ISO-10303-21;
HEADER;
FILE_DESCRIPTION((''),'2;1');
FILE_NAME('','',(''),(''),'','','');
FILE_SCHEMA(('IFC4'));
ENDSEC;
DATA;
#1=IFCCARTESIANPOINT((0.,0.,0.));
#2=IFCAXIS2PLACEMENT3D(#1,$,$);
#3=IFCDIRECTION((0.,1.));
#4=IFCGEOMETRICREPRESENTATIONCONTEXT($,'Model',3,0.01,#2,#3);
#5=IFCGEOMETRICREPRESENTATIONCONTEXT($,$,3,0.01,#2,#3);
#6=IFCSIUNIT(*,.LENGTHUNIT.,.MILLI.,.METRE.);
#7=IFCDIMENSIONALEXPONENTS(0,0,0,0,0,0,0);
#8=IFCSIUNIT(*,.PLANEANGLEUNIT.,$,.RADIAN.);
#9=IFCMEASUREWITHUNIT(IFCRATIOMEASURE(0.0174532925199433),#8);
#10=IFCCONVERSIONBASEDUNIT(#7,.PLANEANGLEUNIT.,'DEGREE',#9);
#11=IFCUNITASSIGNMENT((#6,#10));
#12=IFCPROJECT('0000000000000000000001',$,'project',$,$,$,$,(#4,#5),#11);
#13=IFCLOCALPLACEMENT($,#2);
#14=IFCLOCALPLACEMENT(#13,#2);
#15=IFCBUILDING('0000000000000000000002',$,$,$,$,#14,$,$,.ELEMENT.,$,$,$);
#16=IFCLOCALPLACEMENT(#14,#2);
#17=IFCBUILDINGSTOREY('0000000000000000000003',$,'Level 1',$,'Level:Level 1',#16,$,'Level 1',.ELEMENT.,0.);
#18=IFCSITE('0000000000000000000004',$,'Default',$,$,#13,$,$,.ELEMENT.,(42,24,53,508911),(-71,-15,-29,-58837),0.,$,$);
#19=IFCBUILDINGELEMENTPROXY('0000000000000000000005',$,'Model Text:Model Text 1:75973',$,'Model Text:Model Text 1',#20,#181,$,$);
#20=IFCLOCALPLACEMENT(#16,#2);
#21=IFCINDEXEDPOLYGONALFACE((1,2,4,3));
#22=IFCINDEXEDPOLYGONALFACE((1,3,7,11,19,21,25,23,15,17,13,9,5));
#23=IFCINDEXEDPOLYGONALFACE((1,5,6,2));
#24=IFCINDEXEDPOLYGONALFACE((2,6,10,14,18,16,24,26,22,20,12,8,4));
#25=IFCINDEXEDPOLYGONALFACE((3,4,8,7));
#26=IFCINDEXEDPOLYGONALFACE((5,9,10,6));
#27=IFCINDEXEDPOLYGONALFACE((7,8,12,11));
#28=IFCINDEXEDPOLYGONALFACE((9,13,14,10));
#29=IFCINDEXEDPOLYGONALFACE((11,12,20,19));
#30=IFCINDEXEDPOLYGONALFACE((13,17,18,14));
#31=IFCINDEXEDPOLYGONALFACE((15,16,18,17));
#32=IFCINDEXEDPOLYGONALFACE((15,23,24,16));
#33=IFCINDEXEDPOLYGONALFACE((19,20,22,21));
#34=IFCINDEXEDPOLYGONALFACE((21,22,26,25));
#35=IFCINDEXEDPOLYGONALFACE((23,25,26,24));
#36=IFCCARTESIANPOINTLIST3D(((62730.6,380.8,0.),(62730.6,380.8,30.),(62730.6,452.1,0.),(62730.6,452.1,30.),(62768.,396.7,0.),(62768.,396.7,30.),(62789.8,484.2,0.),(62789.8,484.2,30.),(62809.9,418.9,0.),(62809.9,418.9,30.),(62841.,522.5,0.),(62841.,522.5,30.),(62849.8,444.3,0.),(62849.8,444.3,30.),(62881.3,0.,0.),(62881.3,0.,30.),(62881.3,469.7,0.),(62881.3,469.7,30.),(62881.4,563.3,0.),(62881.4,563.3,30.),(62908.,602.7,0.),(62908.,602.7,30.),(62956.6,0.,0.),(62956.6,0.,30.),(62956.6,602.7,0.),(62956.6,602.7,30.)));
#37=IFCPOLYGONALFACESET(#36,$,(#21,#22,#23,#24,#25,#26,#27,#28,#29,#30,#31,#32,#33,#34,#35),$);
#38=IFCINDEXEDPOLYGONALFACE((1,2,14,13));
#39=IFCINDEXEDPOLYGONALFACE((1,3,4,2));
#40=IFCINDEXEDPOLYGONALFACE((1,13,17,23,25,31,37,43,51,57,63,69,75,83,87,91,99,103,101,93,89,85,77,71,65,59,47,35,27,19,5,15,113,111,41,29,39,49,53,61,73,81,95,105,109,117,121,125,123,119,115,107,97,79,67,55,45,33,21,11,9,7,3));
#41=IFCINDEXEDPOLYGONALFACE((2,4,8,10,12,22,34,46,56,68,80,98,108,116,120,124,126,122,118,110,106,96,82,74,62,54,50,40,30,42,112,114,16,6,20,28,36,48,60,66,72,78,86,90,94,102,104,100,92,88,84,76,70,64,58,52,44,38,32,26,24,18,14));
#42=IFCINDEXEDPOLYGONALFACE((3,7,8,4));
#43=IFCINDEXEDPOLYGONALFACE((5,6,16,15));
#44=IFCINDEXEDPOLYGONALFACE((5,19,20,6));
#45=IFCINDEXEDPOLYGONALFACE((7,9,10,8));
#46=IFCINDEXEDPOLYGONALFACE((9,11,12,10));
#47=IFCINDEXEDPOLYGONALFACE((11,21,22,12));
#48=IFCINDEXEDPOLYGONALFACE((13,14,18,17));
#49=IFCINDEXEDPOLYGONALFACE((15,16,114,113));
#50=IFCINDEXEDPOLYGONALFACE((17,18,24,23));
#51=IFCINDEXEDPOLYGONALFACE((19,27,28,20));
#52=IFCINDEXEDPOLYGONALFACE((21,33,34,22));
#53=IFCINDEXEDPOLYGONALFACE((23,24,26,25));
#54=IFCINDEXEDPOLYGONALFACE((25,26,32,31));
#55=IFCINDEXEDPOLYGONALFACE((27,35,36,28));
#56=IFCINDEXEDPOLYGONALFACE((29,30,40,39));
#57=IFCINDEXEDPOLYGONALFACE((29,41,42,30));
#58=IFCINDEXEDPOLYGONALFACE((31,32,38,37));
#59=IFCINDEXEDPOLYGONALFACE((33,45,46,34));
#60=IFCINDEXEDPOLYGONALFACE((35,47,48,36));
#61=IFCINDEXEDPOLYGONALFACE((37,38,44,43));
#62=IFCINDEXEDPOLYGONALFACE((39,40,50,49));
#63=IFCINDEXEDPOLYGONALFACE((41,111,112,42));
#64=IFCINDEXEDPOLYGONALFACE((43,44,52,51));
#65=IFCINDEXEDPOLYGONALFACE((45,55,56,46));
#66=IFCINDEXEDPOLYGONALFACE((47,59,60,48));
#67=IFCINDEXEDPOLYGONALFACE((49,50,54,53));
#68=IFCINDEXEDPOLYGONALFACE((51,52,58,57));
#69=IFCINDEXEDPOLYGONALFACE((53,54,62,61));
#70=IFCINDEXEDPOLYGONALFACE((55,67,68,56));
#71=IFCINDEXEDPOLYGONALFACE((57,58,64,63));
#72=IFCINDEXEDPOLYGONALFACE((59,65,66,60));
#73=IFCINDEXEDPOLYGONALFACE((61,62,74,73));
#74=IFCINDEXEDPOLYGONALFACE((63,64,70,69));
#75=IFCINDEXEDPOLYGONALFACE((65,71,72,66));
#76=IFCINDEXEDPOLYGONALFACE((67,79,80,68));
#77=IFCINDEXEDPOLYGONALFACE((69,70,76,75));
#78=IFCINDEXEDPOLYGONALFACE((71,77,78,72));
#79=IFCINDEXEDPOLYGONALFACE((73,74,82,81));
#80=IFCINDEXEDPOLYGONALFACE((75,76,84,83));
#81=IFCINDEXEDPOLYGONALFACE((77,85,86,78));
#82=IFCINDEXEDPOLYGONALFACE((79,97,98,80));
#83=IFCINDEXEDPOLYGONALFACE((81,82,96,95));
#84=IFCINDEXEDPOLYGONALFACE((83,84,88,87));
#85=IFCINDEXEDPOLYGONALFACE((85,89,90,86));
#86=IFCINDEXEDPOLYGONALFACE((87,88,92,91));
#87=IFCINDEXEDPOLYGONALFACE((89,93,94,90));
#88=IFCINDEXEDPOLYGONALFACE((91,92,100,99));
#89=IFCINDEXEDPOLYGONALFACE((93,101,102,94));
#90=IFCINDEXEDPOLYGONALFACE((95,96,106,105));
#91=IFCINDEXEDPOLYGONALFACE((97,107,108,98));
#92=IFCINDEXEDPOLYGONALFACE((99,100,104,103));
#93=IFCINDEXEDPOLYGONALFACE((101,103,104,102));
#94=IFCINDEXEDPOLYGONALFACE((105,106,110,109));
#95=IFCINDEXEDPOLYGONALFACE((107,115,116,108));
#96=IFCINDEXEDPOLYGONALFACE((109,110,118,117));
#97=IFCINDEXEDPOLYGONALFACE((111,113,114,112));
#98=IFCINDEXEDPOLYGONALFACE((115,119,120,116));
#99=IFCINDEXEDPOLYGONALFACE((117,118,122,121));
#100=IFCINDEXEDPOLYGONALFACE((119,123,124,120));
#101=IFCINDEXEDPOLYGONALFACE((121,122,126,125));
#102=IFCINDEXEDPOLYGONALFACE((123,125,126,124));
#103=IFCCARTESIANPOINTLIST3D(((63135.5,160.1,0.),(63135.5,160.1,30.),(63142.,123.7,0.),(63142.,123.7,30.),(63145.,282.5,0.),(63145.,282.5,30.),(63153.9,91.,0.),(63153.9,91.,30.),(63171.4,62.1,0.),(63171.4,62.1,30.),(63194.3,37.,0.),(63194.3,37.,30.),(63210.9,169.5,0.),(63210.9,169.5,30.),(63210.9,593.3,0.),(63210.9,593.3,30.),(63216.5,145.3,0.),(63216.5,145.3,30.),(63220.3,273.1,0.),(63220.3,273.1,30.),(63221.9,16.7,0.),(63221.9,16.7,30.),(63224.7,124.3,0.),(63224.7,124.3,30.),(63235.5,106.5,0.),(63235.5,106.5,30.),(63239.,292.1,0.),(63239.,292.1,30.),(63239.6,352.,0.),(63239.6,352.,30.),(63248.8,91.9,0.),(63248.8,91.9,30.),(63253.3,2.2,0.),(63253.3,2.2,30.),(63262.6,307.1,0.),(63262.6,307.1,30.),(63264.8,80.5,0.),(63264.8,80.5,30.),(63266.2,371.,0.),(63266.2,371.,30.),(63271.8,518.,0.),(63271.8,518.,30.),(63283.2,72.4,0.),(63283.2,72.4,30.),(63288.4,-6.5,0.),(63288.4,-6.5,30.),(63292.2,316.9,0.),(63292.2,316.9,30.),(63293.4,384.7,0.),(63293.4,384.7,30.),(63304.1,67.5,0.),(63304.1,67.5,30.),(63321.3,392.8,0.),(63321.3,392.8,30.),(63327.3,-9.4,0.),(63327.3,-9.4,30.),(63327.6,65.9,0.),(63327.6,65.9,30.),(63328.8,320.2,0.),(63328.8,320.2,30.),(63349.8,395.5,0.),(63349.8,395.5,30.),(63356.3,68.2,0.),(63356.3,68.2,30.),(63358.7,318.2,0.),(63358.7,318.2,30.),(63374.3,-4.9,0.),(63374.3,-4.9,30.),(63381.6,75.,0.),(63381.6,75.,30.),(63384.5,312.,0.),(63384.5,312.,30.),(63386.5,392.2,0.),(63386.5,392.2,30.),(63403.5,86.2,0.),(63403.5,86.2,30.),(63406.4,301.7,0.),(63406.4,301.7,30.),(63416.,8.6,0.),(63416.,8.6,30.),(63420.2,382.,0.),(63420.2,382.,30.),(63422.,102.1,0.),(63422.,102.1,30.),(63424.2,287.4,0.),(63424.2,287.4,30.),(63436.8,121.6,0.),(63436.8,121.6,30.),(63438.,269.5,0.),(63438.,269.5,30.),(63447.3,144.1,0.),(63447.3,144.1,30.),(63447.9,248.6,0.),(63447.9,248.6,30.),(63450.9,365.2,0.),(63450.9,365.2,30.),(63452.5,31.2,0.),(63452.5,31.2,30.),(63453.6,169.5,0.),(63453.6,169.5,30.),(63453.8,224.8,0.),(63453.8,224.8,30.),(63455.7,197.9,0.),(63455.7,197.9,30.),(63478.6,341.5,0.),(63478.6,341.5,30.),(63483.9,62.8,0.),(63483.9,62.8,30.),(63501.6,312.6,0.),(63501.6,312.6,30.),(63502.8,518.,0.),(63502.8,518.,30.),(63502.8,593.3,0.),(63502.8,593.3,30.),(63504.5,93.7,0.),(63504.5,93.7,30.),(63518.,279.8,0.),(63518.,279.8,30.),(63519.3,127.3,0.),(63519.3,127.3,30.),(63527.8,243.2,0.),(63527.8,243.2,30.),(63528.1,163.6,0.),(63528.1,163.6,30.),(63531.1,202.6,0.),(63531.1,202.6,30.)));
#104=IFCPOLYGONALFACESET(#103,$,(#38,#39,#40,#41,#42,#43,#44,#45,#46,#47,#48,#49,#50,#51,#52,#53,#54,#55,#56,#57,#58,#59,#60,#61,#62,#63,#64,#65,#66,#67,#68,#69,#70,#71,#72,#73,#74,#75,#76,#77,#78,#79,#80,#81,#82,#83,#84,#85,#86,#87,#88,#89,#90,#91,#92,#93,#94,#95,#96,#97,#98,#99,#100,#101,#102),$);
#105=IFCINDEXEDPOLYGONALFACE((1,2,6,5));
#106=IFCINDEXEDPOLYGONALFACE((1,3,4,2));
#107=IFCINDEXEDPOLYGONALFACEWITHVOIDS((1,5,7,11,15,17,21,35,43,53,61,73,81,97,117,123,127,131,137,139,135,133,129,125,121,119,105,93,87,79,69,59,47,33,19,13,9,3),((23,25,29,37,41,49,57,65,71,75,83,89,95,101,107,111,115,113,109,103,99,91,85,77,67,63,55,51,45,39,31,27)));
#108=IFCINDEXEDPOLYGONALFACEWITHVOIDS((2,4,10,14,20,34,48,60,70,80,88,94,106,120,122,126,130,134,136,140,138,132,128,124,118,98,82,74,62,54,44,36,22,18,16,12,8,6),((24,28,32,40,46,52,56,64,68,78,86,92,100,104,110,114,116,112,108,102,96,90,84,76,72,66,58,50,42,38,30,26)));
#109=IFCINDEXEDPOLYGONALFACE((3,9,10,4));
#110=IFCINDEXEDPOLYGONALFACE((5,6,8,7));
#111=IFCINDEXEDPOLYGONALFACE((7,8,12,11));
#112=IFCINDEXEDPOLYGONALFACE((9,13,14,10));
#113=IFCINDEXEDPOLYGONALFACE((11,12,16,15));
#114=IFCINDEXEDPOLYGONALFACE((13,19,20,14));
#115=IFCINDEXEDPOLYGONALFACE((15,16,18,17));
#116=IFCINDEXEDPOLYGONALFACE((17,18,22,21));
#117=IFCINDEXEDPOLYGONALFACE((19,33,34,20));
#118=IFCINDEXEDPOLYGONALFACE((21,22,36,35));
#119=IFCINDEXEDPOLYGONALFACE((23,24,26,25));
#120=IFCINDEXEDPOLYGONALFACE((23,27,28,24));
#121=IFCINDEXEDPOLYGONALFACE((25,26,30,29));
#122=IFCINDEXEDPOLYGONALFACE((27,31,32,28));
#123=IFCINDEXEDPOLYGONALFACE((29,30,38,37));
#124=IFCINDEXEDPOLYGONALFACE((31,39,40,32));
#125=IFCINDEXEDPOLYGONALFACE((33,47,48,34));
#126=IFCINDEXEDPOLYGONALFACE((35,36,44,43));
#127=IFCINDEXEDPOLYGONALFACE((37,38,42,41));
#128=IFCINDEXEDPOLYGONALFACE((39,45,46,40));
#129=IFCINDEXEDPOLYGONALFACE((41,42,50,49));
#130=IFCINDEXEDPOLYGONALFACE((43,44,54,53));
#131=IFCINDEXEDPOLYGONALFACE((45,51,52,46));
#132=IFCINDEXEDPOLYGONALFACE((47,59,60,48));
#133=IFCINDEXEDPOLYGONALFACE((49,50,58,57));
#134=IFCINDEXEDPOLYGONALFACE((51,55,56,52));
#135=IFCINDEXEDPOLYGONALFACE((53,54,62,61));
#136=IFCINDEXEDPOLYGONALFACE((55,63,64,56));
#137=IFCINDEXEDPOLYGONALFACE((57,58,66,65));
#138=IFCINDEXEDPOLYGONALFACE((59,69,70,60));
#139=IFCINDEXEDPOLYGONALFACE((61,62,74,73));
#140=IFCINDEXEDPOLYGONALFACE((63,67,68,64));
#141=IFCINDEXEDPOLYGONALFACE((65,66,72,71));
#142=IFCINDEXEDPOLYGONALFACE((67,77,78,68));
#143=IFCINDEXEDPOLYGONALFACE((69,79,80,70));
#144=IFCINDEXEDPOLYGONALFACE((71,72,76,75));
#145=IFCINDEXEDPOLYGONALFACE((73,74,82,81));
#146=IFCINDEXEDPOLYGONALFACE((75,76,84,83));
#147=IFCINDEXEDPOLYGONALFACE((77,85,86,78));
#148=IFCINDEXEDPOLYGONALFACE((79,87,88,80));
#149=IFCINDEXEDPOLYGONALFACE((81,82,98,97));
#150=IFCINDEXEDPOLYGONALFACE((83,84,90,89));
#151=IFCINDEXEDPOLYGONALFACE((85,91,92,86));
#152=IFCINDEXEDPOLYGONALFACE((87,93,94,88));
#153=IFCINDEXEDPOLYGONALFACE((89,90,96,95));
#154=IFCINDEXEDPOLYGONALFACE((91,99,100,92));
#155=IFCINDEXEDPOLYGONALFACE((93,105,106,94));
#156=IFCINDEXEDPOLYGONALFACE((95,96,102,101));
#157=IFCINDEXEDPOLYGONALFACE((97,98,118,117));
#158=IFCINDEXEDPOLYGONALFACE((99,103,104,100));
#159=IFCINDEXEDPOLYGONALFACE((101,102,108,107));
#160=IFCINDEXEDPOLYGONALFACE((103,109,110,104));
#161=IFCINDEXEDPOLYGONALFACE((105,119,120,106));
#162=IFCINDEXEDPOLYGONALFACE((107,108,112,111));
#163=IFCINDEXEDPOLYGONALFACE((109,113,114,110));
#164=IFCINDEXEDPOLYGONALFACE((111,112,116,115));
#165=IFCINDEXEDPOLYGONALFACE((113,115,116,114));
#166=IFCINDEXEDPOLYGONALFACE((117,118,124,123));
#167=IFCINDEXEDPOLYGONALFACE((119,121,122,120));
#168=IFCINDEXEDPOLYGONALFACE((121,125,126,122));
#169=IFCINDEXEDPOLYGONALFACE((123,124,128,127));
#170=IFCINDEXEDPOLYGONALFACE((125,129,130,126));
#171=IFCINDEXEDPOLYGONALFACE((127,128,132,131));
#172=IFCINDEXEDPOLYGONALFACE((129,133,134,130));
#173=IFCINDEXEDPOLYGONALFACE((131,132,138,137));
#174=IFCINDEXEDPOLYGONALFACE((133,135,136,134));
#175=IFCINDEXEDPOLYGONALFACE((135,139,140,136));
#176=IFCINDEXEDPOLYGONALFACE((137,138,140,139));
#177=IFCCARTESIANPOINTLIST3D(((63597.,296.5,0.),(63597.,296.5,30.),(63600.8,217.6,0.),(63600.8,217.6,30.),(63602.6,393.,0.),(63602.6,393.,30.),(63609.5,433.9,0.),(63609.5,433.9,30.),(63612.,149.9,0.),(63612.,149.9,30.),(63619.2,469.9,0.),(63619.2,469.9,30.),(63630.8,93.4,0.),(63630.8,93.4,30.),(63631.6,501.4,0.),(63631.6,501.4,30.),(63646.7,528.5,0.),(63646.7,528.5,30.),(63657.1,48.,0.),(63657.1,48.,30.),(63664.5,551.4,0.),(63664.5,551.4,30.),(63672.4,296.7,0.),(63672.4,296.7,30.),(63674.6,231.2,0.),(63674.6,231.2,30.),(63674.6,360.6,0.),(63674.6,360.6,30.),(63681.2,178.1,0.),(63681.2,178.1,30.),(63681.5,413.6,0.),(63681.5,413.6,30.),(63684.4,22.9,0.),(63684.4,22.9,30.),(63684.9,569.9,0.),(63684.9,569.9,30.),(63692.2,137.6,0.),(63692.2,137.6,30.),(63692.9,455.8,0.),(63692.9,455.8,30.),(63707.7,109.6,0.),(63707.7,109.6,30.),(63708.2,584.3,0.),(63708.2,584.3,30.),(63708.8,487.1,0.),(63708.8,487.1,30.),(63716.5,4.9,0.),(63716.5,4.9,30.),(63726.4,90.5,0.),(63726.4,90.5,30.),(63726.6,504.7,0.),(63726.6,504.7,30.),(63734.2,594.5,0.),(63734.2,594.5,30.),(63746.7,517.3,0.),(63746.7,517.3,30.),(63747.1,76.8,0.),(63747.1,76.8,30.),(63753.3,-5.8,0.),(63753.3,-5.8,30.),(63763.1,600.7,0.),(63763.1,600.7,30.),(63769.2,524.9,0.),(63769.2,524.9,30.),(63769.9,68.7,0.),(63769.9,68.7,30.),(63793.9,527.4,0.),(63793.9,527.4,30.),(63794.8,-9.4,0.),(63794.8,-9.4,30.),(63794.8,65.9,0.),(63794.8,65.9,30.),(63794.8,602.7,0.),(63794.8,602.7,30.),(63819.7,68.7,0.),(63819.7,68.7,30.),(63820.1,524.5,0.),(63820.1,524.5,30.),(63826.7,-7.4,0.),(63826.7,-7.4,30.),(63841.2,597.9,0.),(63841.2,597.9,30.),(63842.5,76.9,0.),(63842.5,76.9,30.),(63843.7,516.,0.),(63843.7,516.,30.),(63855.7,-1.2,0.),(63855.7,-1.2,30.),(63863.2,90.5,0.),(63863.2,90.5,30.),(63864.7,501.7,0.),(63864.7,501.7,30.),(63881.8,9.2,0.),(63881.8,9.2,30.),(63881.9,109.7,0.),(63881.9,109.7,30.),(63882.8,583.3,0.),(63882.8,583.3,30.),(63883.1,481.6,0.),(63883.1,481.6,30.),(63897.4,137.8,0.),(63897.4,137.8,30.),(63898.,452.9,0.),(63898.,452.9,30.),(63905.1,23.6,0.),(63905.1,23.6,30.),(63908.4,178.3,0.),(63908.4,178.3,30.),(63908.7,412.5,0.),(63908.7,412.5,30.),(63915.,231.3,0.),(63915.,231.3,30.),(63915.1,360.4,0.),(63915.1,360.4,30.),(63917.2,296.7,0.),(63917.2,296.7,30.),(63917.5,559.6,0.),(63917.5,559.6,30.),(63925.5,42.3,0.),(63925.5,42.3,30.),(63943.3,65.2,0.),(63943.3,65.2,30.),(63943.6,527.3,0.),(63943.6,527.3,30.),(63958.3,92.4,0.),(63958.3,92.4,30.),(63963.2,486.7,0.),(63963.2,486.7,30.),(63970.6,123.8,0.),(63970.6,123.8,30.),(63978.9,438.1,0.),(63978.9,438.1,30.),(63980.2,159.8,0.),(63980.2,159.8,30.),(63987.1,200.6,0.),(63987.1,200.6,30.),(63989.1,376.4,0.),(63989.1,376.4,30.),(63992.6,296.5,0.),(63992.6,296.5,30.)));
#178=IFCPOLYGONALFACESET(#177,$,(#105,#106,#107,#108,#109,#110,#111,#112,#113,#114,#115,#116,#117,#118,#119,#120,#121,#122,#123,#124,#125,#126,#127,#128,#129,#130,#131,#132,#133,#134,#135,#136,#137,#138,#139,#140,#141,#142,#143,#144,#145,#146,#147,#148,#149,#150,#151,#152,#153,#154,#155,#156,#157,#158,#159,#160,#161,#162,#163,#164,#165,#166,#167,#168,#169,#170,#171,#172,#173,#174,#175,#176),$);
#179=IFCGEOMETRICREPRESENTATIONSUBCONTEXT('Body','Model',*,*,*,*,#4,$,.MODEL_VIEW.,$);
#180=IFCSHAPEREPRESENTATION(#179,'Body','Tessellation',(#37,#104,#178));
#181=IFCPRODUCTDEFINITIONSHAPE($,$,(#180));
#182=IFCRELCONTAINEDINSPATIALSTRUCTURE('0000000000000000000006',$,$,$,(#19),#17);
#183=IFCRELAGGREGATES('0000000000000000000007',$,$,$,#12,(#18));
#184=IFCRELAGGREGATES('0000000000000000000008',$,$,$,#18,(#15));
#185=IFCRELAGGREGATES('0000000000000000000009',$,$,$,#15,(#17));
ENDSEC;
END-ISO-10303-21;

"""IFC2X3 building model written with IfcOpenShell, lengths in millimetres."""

from ifc_helpers import new_model, entity, si_unit, converted_unit, direction, frame, origin, place, context, subcontext, project, spatial, polyline, outline, extrude, element, save


model = new_model("IFC2X3")

# Units and contexts
model_context = context("Model", 3, precision=0.01, world=origin(), true_north=direction((0.0, 1.0)))
context_of_model = context(None, 3, precision=0.01, world=origin(), true_north=direction((0.0, 1.0)))
body_context = subcontext(model_context, "Body", "Model", "MODEL_VIEW")
ifc_project = project(units=[si_unit("LENGTHUNIT", "METRE", prefix="MILLI"), converted_unit("PLANEANGLEUNIT", "DEGREE", entity("IfcRatioMeasure", 0.0174532925199433), si_unit("PLANEANGLEUNIT", "RADIAN"), dimensions=[0, 0, 0, 0, 0, 0, 0])], contexts=[model_context, context_of_model])

# Site, building, storey
site_placement = place(None, origin())
site = spatial("IfcSite", under=ifc_project, at=site_placement, Name="Default", CompositionType="ELEMENT", RefLatitude=(42, 24, 53, 508911), RefLongitude=(-71, -15, -29, -58837), RefElevation=0.0)
building_placement = place(site_placement, origin())
building = spatial("IfcBuilding", under=site, at=building_placement, CompositionType="ELEMENT")
storey_placement = place(building_placement, origin())
storey = spatial("IfcBuildingStorey", under=building, at=storey_placement, Name="Level 1", ObjectType="Level:Level 1", LongName="Level 1", CompositionType="ELEMENT", Elevation=0.0)

# Building element proxy
proxy_1_placement = place(storey_placement, origin())
element("IfcBuildingElementProxy", 1, at=proxy_1_placement, inside=storey, Name="Model Text:Model Text 1:75973", ObjectType="Model Text:Model Text 1", context=body_context, shape_type="SweptSolid", body=[
    extrude(outline(polyline([(-410.6, -111.6), (192.1, -111.6), (192.1, -63.1), (152.7, -36.4), (111.9, 4.0), (73.6, 55.2), (41.4, 114.4), (-29.8, 114.4), (-13.9, 77.0), (8.3, 35.1), (33.7, -4.8), (59.1, -36.3), (-410.6, -36.3), (-410.6, -111.6)])), frame((62845.0, 410.6, 0.0), z_axis=(0.0, 0.0, 1.0), x_axis=(0.0, 1.0, 0.0)), (0.0, 0.0, 1.0), 30.0),
    extrude(outline(polyline([(12.1, -219.3), (49.1, -219.3), (83.4, -213.2), (114.8, -201.1), (143.5, -182.8), (168.3, -159.2), (188.1, -130.8), (202.8, -97.8), (212.4, -60.0), (216.1, -12.9), (210.0, 30.5), (194.1, 70.4), (168.4, 106.8), (141.6, 132.5), (111.1, 152.9), (76.9, 167.9), (39.0, 177.6), (-1.5, 181.4), (-39.3, 178.1), (-74.4, 167.6), (-106.9, 150.1), (-135.0, 126.9), (-157.0, 99.6), (-172.8, 68.1), (-182.5, 32.6), (-184.8, 4.0), (-181.6, -24.8), (-172.9, -54.0), (-158.8, -83.5), (-316.6, -22.9), (-276.5, 204.6), (-350.7, 217.7), (-401.4, -69.8), (-106.8, -188.8), (-84.5, -116.2), (-99.9, -94.5), (-110.6, -68.6), (-115.1, -37.8), (-112.0, -1.2), (-104.8, 27.9), (-94.2, 52.3), (-80.3, 72.0), (-63.1, 87.0), (-43.0, 97.5), (-20.8, 103.6), (3.8, 105.3), (30.5, 102.6), (58.1, 95.6), (82.1, 84.9), (102.4, 70.6), (119.1, 52.7), (131.4, 31.7), (138.7, 8.2), (141.0, -17.9), (138.2, -46.6), (132.6, -69.4), (124.1, -89.2), (112.9, -105.9), (99.0, -119.6), (82.3, -130.2), (62.9, -137.7), (40.8, -142.2), (15.9, -143.5), (12.1, -219.3)])), frame((63349.4, 210.2, 0.0), z_axis=(0.0, 0.0, 1.0), x_axis=(0.173842, -0.984774, 0.0)), (0.0, 0.0, 1.0), 30.0),
    extrude(outline(polyline([(-10.6, -198.7), (68.3, -198.7), (136.5, -190.7), (193.9, -174.7), (240.5, -150.6), (266.9, -124.4), (286.3, -93.2), (298.8, -57.0), (304.3, -15.7), (303.8, 16.2), (299.0, 45.5), (289.9, 72.1), (276.6, 96.0), (258.9, 117.3), (236.9, 136.2), (210.4, 152.5), (179.6, 166.3), (144.1, 177.6), (103.7, 186.3), (8.2, 196.4), (-71.8, 196.7), (-134.0, 189.4), (-183.3, 176.1), (-224.7, 158.4), (-258.2, 133.9), (-283.5, 100.3), (-300.1, 59.5), (-307.1, 13.4), (-306.6, -18.4), (-301.8, -47.5), (-292.8, -74.0), (-279.6, -97.9), (-262.0, -119.2), (-240.0, -138.1), (-213.6, -154.5), (-182.8, -168.4), (-147.3, -179.8), (-106.7, -188.6), (-10.6, -198.7)]), holes=[polyline([(-7.2, -123.5), (-71.0, -118.2), (-123.6, -108.8), (-165.2, -95.4), (-195.7, -78.0), (-212.4, -59.4), (-224.1, -38.7), (-230.6, -15.9), (-231.9, 8.9), (-227.8, 35.0), (-218.1, 58.1), (-202.8, 78.4), (-182.0, 95.8), (-152.6, 109.4), (-111.7, 118.1), (-59.4, 122.0), (4.4, 121.1), (69.6, 115.8), (122.2, 106.7), (162.2, 93.7), (189.5, 77.0), (207.7, 57.4), (220.4, 36.0), (227.5, 12.8), (229.1, -12.1), (225.2, -36.8), (215.9, -59.2), (201.3, -79.3), (181.4, -97.1), (152.6, -111.2), (111.6, -120.3), (58.3, -124.4), (-7.2, -123.5)])]), frame((63796.0, 295.3, 0.0), z_axis=(0.0, 0.0, 1.0), x_axis=(0.047515, -0.998871, 0.0)), (0.0, 0.0, 1.0), 30.0),
])

save(model, "model.ifc")
